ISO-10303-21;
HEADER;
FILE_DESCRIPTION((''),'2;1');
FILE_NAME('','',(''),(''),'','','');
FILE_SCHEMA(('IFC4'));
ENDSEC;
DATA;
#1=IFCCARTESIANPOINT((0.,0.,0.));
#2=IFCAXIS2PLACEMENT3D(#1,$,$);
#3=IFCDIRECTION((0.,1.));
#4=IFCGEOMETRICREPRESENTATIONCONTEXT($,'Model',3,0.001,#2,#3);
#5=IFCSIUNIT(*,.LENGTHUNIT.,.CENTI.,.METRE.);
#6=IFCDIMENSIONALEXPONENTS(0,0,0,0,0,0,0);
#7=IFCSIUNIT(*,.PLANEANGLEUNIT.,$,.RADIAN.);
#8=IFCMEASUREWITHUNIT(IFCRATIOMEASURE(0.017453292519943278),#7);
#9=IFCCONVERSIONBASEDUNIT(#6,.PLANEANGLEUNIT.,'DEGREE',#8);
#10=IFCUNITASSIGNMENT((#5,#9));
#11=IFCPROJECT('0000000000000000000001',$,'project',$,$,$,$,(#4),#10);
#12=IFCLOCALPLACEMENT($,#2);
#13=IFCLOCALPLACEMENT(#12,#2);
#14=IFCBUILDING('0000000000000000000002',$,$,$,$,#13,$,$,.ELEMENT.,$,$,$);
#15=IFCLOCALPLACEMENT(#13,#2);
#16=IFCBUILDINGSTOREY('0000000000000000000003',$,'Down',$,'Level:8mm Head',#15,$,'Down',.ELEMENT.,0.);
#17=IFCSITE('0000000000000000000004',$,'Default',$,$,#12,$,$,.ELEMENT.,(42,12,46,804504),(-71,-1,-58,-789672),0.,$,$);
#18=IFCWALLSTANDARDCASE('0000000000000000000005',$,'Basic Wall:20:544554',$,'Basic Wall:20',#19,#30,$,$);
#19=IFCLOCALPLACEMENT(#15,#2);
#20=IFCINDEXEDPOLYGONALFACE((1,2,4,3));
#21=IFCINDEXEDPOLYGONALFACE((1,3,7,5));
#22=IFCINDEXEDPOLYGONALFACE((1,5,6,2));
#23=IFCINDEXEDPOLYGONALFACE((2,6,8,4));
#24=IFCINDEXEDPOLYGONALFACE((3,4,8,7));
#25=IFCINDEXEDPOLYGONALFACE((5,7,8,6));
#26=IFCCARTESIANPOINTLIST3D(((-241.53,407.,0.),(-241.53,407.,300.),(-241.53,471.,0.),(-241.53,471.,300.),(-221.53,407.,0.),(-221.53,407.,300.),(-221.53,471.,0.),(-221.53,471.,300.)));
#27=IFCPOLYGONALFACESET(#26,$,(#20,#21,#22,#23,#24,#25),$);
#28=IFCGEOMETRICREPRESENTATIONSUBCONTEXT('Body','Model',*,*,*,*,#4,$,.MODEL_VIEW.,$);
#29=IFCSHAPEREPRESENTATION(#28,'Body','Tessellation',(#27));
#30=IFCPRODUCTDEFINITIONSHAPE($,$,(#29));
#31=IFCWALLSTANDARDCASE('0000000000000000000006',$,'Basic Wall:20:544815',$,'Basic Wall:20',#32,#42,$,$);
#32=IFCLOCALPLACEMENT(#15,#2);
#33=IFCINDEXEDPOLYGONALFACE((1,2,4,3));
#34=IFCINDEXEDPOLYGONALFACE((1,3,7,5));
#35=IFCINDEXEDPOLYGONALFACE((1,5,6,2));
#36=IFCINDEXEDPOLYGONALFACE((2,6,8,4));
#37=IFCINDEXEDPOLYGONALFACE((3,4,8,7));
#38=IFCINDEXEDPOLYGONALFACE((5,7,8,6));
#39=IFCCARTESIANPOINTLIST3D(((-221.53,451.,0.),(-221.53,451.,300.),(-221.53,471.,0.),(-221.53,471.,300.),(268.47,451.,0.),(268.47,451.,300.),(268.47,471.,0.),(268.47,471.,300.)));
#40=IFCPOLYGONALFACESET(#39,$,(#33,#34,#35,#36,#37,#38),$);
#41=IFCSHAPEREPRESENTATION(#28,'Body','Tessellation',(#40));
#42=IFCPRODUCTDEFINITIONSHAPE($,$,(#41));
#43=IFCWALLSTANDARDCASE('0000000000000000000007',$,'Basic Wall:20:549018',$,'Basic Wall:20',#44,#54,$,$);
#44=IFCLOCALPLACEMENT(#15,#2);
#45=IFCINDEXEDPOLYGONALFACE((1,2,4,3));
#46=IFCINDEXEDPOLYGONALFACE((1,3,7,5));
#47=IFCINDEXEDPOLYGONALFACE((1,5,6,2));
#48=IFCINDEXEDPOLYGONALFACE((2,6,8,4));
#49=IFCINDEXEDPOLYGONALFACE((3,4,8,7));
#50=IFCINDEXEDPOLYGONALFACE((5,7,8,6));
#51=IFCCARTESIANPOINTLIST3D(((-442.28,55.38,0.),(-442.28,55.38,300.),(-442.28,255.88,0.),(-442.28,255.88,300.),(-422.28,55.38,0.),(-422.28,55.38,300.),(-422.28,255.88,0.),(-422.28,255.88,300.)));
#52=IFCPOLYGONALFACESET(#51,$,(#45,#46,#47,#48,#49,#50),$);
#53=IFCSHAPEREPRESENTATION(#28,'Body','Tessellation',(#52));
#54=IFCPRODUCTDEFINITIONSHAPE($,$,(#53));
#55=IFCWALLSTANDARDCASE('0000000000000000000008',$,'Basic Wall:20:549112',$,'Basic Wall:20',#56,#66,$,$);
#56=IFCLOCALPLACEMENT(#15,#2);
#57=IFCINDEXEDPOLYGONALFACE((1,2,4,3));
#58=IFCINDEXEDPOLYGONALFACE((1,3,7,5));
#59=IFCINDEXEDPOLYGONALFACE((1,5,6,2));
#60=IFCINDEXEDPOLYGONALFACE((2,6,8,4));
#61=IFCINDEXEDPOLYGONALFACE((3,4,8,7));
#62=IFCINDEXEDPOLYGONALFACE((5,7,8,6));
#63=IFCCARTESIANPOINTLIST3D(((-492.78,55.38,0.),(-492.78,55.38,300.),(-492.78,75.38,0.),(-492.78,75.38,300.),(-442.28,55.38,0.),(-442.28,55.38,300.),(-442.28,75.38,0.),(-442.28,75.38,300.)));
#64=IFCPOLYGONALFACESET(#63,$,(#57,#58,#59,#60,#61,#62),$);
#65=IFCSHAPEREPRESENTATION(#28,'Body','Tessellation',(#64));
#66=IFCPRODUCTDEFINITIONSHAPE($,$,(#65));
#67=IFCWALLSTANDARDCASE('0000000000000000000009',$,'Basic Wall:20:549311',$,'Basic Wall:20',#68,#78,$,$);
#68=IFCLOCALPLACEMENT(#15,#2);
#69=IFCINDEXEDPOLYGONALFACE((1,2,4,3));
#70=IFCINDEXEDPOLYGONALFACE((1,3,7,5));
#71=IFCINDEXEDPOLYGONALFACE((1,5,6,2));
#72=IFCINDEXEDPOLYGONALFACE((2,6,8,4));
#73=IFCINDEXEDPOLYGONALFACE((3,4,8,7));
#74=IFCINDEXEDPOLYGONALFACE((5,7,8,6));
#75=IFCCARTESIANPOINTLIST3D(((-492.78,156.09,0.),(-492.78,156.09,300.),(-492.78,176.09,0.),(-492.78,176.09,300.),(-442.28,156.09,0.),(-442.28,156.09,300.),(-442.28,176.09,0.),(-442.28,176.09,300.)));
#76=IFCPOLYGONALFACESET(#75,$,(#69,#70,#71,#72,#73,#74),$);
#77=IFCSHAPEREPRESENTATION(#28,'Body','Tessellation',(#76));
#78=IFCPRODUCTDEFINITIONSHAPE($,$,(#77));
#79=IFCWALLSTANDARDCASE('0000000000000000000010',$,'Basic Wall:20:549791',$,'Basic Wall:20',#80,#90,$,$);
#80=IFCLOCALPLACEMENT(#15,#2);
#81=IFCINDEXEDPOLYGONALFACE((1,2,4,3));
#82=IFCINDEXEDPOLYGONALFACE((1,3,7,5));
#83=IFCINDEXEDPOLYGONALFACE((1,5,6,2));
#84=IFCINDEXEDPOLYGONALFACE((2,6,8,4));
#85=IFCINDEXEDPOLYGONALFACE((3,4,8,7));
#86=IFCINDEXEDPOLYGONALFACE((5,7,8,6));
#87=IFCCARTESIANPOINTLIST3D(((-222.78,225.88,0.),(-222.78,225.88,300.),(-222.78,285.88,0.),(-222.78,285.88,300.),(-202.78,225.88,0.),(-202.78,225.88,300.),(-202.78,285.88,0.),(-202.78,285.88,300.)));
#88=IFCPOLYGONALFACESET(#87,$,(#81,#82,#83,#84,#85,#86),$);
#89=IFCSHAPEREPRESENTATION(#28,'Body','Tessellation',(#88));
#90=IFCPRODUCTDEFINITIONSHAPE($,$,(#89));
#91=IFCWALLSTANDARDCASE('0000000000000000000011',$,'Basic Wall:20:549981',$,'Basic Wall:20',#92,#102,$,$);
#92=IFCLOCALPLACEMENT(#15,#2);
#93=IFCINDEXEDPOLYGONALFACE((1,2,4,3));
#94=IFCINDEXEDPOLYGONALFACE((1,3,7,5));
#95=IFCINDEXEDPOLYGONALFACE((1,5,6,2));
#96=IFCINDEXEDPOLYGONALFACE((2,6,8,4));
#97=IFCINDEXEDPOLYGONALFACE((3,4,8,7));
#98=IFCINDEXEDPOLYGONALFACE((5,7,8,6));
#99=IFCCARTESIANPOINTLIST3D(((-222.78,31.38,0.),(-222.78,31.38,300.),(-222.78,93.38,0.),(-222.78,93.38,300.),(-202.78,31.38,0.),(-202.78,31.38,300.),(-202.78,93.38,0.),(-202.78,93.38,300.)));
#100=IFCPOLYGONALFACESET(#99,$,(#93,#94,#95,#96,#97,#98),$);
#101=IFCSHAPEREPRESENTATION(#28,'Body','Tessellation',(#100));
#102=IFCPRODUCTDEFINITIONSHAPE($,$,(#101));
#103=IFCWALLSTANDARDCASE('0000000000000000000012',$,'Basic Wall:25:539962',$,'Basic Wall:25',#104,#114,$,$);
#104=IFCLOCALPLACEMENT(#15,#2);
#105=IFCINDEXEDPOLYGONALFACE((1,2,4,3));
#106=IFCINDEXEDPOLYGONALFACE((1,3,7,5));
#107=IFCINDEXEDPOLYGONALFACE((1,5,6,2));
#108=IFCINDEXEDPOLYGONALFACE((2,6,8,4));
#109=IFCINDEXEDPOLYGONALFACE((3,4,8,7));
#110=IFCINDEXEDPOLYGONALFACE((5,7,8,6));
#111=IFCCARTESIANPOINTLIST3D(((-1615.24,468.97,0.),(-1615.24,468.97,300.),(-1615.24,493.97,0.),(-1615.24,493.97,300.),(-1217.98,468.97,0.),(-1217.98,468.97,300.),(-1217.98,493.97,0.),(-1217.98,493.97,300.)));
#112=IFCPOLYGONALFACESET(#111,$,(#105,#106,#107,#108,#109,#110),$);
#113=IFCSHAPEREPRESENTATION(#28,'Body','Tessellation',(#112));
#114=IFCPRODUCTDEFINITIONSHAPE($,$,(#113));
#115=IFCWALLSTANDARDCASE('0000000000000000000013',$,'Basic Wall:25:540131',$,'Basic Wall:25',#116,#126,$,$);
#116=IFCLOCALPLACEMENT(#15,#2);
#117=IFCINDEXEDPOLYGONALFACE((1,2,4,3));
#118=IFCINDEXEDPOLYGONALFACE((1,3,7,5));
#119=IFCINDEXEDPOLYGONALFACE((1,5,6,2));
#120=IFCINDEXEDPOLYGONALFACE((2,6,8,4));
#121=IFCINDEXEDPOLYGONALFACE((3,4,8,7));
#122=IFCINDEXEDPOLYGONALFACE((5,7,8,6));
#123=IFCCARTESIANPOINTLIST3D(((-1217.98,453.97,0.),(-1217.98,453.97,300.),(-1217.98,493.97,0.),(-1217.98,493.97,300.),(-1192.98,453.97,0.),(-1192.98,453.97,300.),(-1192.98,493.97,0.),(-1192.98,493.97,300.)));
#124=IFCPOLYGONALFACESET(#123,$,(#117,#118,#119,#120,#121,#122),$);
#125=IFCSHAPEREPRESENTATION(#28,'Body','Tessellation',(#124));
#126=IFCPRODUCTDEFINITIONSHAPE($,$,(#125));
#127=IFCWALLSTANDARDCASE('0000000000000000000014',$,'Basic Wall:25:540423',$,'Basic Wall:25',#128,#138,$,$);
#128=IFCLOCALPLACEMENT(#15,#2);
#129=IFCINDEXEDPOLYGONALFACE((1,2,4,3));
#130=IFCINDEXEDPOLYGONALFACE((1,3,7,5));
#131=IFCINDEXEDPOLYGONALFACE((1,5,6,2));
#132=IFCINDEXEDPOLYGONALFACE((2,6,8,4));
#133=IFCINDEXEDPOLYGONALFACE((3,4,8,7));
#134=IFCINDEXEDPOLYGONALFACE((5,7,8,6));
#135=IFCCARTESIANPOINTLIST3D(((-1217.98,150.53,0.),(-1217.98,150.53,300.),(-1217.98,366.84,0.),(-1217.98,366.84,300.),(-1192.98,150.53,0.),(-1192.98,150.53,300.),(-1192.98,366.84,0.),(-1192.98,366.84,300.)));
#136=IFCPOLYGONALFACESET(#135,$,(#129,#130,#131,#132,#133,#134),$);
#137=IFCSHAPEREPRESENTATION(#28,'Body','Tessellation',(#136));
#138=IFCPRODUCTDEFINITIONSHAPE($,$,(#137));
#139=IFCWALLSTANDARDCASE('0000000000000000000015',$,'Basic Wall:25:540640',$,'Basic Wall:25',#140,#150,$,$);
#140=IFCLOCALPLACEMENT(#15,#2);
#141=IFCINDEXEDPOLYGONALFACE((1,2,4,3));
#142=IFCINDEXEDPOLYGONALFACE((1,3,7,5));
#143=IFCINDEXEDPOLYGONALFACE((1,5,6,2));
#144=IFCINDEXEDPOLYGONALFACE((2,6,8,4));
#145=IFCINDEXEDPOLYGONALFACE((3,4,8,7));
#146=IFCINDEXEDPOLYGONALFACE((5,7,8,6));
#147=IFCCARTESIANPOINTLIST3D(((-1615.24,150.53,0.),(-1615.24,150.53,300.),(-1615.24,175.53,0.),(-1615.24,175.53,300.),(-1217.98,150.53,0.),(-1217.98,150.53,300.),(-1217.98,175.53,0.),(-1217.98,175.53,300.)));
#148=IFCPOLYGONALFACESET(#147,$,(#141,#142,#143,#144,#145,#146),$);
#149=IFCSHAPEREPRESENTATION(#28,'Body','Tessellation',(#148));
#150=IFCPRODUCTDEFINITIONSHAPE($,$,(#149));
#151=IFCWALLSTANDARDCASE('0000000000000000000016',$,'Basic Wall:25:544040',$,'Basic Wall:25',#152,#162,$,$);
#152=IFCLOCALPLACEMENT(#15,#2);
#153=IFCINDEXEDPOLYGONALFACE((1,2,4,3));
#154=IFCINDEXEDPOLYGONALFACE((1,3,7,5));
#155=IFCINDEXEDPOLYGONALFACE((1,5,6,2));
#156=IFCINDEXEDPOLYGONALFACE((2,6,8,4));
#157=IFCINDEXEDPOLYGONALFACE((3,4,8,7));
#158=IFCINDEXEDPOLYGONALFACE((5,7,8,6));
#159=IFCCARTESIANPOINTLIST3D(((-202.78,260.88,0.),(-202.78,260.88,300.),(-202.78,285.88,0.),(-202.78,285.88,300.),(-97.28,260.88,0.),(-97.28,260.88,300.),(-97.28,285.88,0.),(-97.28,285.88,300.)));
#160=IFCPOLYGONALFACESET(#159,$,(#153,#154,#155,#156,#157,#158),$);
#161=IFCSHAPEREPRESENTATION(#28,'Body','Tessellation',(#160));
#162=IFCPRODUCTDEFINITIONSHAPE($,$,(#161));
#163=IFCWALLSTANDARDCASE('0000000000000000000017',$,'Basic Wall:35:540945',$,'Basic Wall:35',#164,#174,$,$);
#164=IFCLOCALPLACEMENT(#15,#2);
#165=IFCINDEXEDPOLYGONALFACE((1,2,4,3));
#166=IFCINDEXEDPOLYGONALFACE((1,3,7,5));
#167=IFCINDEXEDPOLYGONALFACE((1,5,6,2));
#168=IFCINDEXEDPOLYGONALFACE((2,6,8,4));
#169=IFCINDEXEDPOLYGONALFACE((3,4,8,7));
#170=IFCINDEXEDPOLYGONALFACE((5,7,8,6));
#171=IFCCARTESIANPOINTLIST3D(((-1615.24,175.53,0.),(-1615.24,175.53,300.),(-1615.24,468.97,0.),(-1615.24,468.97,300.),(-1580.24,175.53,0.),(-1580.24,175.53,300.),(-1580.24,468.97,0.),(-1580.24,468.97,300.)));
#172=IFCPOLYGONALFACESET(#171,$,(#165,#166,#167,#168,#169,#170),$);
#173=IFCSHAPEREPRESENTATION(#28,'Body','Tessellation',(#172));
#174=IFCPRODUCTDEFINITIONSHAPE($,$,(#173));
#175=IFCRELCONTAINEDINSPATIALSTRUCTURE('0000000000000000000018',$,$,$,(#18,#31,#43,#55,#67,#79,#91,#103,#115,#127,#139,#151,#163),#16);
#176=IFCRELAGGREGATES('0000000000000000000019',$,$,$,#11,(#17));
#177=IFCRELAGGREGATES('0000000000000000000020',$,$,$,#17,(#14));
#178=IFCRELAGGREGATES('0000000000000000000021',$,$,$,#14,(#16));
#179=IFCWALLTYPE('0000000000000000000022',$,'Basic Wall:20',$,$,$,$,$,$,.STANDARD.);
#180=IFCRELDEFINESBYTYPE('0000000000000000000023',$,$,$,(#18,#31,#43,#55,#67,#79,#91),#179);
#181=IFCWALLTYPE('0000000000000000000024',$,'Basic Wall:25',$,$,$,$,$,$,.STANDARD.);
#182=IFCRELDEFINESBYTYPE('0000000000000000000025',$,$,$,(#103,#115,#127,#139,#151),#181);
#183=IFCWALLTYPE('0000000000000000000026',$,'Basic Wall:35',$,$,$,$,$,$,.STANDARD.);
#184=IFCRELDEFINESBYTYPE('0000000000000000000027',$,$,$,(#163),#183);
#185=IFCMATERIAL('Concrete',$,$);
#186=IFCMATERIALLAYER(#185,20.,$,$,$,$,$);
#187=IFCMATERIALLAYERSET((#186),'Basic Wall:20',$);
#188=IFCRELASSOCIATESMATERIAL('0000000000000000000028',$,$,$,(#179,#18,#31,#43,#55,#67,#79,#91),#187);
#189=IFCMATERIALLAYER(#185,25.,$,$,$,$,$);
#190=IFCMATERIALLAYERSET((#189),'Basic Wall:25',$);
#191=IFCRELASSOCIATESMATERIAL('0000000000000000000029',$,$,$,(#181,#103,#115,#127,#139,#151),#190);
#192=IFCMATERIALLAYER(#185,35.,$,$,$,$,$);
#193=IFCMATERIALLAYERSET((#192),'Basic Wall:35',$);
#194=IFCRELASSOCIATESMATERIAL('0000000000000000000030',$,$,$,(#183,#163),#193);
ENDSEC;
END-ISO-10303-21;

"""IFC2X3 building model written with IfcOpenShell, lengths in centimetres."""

from ifc_helpers import new_model, entity, si_unit, converted_unit, direction, frame, frame_2d, origin, place, context, subcontext, project, spatial, rectangle, extrude, material, layer, layer_set, layer_usage, type_object, element, save


model = new_model("IFC2X3")

# Units and contexts
model_context = context("Model", 3, precision=0.001, world=origin(), true_north=direction((0.0, 1.0)))
body_context = subcontext(model_context, "Body", "Model", "MODEL_VIEW")
ifc_project = project(units=[si_unit("LENGTHUNIT", "METRE", prefix="CENTI"), converted_unit("PLANEANGLEUNIT", "DEGREE", entity("IfcRatioMeasure", 0.017453292519943278), si_unit("PLANEANGLEUNIT", "RADIAN"), dimensions=[0, 0, 0, 0, 0, 0, 0])], contexts=[model_context])

# Site, building, storey
site_placement = place(None, origin())
site = spatial("IfcSite", under=ifc_project, at=site_placement, Name="Default", CompositionType="ELEMENT", RefLatitude=(42, 12, 46, 804504), RefLongitude=(-71, -1, -58, -789672), RefElevation=0.0)
building_placement = place(site_placement, origin())
building = spatial("IfcBuilding", under=site, at=building_placement, CompositionType="ELEMENT")
storey_placement = place(building_placement, origin())
storey = spatial("IfcBuildingStorey", under=building, at=storey_placement, Name="Down", ObjectType="Level:8mm Head", LongName="Down", CompositionType="ELEMENT", Elevation=0.0)

# Shared definitions
ifc_material = material(Name="Concrete")

# Walls
ifc_layer_1 = layer(ifc_material, 20.0)
ifc_layer_set_1 = layer_set([ifc_layer_1], Name="Basic Wall:20")
wall_type_1 = type_object("IfcWallType", Name="Basic Wall:20", PredefinedType="STANDARD", material=ifc_layer_set_1)
ifc_layer_usage_1 = layer_usage(ifc_layer_set_1, "AXIS2", "POSITIVE", -10.0)
wall_1_placement = place(storey_placement, frame((-231.53, 407.0, 0.0), z_axis=(0.0, 0.0, 1.0), x_axis=(0.0, 1.0, 0.0)))
element("IfcWallStandardCase", 1, at=wall_1_placement, inside=storey, type_object=wall_type_1, material=ifc_layer_usage_1, Name="Basic Wall:20:544554", ObjectType="Basic Wall:20", context=body_context, shape_type="SweptSolid", body=[
    extrude(rectangle(XDim=64.0, YDim=20.0, at=frame_2d((32.0, 0.0), x_axis=(-1.0, 0.0))), origin(), (0.0, 0.0, 1.0), 300.0),
])
ifc_layer_usage_2 = layer_usage(ifc_layer_set_1, "AXIS2", "NEGATIVE", 10.0)
wall_2_placement = place(storey_placement, frame((-221.53, 461.0, 0.0)))
element("IfcWallStandardCase", 2, at=wall_2_placement, inside=storey, type_object=wall_type_1, material=ifc_layer_usage_2, Name="Basic Wall:20:544815", ObjectType="Basic Wall:20", context=body_context, shape_type="SweptSolid", body=[
    extrude(rectangle(XDim=490.0, YDim=20.0, at=frame_2d((245.0, 0.0), x_axis=(-1.0, 0.0))), origin(), (0.0, 0.0, 1.0), 300.0),
])
ifc_layer_usage_3 = layer_usage(ifc_layer_set_1, "AXIS2", "POSITIVE", -10.0)
wall_3_placement = place(storey_placement, frame((-432.28, 255.88, 0.0), z_axis=(0.0, 0.0, 1.0), x_axis=(0.0, -1.0, 0.0)))
element("IfcWallStandardCase", 3, at=wall_3_placement, inside=storey, type_object=wall_type_1, material=ifc_layer_usage_3, Name="Basic Wall:20:549018", ObjectType="Basic Wall:20", context=body_context, shape_type="SweptSolid", body=[
    extrude(rectangle(XDim=200.5, YDim=20.0, at=frame_2d((100.25, 0.0), x_axis=(-1.0, 0.0))), origin(), (0.0, 0.0, 1.0), 300.0),
])
ifc_layer_usage_4 = layer_usage(ifc_layer_set_1, "AXIS2", "NEGATIVE", 10.0)
wall_4_placement = place(storey_placement, frame((-442.28, 65.38, 0.0), z_axis=(0.0, 0.0, 1.0), x_axis=(-1.0, 0.0, 0.0)))
element("IfcWallStandardCase", 4, at=wall_4_placement, inside=storey, type_object=wall_type_1, material=ifc_layer_usage_4, Name="Basic Wall:20:549112", ObjectType="Basic Wall:20", context=body_context, shape_type="SweptSolid", body=[
    extrude(rectangle(XDim=50.5, YDim=20.0, at=frame_2d((25.25, 0.0), x_axis=(-1.0, 0.0))), origin(), (0.0, 0.0, 1.0), 300.0),
])
ifc_layer_usage_5 = layer_usage(ifc_layer_set_1, "AXIS2", "POSITIVE", -10.0)
wall_5_placement = place(storey_placement, frame((-442.28, 166.09, 0.0), z_axis=(0.0, 0.0, 1.0), x_axis=(-1.0, 0.0, 0.0)))
element("IfcWallStandardCase", 5, at=wall_5_placement, inside=storey, type_object=wall_type_1, material=ifc_layer_usage_5, Name="Basic Wall:20:549311", ObjectType="Basic Wall:20", context=body_context, shape_type="SweptSolid", body=[
    extrude(rectangle(XDim=50.5, YDim=20.0, at=frame_2d((25.25, 0.0), x_axis=(-1.0, 0.0))), origin(), (0.0, 0.0, 1.0), 300.0),
])
ifc_layer_usage_6 = layer_usage(ifc_layer_set_1, "AXIS2", "NEGATIVE", 10.0)
wall_6_placement = place(storey_placement, frame((-212.78, 285.88, 0.0), z_axis=(0.0, 0.0, 1.0), x_axis=(0.0, -1.0, 0.0)))
element("IfcWallStandardCase", 6, at=wall_6_placement, inside=storey, type_object=wall_type_1, material=ifc_layer_usage_6, Name="Basic Wall:20:549791", ObjectType="Basic Wall:20", context=body_context, shape_type="SweptSolid", body=[
    extrude(rectangle(XDim=60.0, YDim=20.0, at=frame_2d((30.0, 0.0), x_axis=(-1.0, 0.0))), origin(), (0.0, 0.0, 1.0), 300.0),
])
ifc_layer_usage_7 = layer_usage(ifc_layer_set_1, "AXIS2", "NEGATIVE", 10.0)
wall_7_placement = place(storey_placement, frame((-212.78, 93.38, 0.0), z_axis=(0.0, 0.0, 1.0), x_axis=(0.0, -1.0, 0.0)))
element("IfcWallStandardCase", 7, at=wall_7_placement, inside=storey, type_object=wall_type_1, material=ifc_layer_usage_7, Name="Basic Wall:20:549981", ObjectType="Basic Wall:20", context=body_context, shape_type="SweptSolid", body=[
    extrude(rectangle(XDim=62.0, YDim=20.0, at=frame_2d((31.0, 0.0), x_axis=(-1.0, 0.0))), origin(), (0.0, 0.0, 1.0), 300.0),
])
ifc_layer_2 = layer(ifc_material, 25.0)
ifc_layer_set_2 = layer_set([ifc_layer_2], Name="Basic Wall:25")
ifc_layer_usage_8 = layer_usage(ifc_layer_set_2, "AXIS2", "POSITIVE", -12.5)
wall_type_2 = type_object("IfcWallType", Name="Basic Wall:25", PredefinedType="STANDARD", material=ifc_layer_set_2)
wall_8_placement = place(storey_placement, frame((-1217.98, 481.47, 0.0), z_axis=(0.0, 0.0, 1.0), x_axis=(-1.0, 0.0, 0.0)))
element("IfcWallStandardCase", 8, at=wall_8_placement, inside=storey, type_object=wall_type_2, material=ifc_layer_usage_8, Name="Basic Wall:25:539962", ObjectType="Basic Wall:25", context=body_context, shape_type="SweptSolid", body=[
    extrude(rectangle(XDim=397.26, YDim=25.0, at=frame_2d((198.63, 0.0), x_axis=(-1.0, 0.0))), origin(), (0.0, 0.0, 1.0), 300.0),
])
ifc_layer_usage_9 = layer_usage(ifc_layer_set_2, "AXIS2", "NEGATIVE", 12.5)
wall_9_placement = place(storey_placement, frame((-1205.48, 493.97, 0.0), z_axis=(0.0, 0.0, 1.0), x_axis=(0.0, -1.0, 0.0)))
element("IfcWallStandardCase", 9, at=wall_9_placement, inside=storey, type_object=wall_type_2, material=ifc_layer_usage_9, Name="Basic Wall:25:540131", ObjectType="Basic Wall:25", context=body_context, shape_type="SweptSolid", body=[
    extrude(rectangle(XDim=40.0, YDim=25.0, at=frame_2d((20.0, 0.0), x_axis=(-1.0, 0.0))), origin(), (0.0, 0.0, 1.0), 300.0),
])
ifc_layer_usage_10 = layer_usage(ifc_layer_set_2, "AXIS2", "NEGATIVE", 12.5)
wall_10_placement = place(storey_placement, frame((-1205.48, 366.84, 0.0), z_axis=(0.0, 0.0, 1.0), x_axis=(0.0, -1.0, 0.0)))
element("IfcWallStandardCase", 10, at=wall_10_placement, inside=storey, type_object=wall_type_2, material=ifc_layer_usage_10, Name="Basic Wall:25:540423", ObjectType="Basic Wall:25", context=body_context, shape_type="SweptSolid", body=[
    extrude(rectangle(XDim=216.31, YDim=25.0, at=frame_2d((108.15, 0.0), x_axis=(-1.0, 0.0))), origin(), (0.0, 0.0, 1.0), 300.0),
])
ifc_layer_usage_11 = layer_usage(ifc_layer_set_2, "AXIS2", "NEGATIVE", 12.5)
wall_11_placement = place(storey_placement, frame((-1217.98, 163.03, 0.0), z_axis=(0.0, 0.0, 1.0), x_axis=(-1.0, 0.0, 0.0)))
element("IfcWallStandardCase", 11, at=wall_11_placement, inside=storey, type_object=wall_type_2, material=ifc_layer_usage_11, Name="Basic Wall:25:540640", ObjectType="Basic Wall:25", context=body_context, shape_type="SweptSolid", body=[
    extrude(rectangle(XDim=397.26, YDim=25.0, at=frame_2d((198.63, 0.0), x_axis=(-1.0, 0.0))), origin(), (0.0, 0.0, 1.0), 300.0),
])
ifc_layer_usage_12 = layer_usage(ifc_layer_set_2, "AXIS2", "NEGATIVE", 12.5)
wall_12_placement = place(storey_placement, frame((-202.78, 273.38, 0.0)))
element("IfcWallStandardCase", 12, at=wall_12_placement, inside=storey, type_object=wall_type_2, material=ifc_layer_usage_12, Name="Basic Wall:25:544040", ObjectType="Basic Wall:25", context=body_context, shape_type="SweptSolid", body=[
    extrude(rectangle(XDim=105.5, YDim=25.0, at=frame_2d((52.75, 0.0), x_axis=(-1.0, 0.0))), origin(), (0.0, 0.0, 1.0), 300.0),
])
ifc_layer_3 = layer(ifc_material, 35.0)
ifc_layer_set_3 = layer_set([ifc_layer_3], Name="Basic Wall:35")
ifc_layer_usage_13 = layer_usage(ifc_layer_set_3, "AXIS2", "POSITIVE", -17.5)
wall_type_3 = type_object("IfcWallType", Name="Basic Wall:35", PredefinedType="STANDARD", material=ifc_layer_set_3)
wall_13_placement = place(storey_placement, frame((-1597.74, 175.53, 0.0), z_axis=(0.0, 0.0, 1.0), x_axis=(0.0, 1.0, 0.0)))
element("IfcWallStandardCase", 13, at=wall_13_placement, inside=storey, type_object=wall_type_3, material=ifc_layer_usage_13, Name="Basic Wall:35:540945", ObjectType="Basic Wall:35", context=body_context, shape_type="SweptSolid", body=[
    extrude(rectangle(XDim=293.44, YDim=35.0, at=frame_2d((146.72, 0.0), x_axis=(-1.0, 0.0))), origin(), (0.0, 0.0, 1.0), 300.0),
])

save(model, "model.ifc")
